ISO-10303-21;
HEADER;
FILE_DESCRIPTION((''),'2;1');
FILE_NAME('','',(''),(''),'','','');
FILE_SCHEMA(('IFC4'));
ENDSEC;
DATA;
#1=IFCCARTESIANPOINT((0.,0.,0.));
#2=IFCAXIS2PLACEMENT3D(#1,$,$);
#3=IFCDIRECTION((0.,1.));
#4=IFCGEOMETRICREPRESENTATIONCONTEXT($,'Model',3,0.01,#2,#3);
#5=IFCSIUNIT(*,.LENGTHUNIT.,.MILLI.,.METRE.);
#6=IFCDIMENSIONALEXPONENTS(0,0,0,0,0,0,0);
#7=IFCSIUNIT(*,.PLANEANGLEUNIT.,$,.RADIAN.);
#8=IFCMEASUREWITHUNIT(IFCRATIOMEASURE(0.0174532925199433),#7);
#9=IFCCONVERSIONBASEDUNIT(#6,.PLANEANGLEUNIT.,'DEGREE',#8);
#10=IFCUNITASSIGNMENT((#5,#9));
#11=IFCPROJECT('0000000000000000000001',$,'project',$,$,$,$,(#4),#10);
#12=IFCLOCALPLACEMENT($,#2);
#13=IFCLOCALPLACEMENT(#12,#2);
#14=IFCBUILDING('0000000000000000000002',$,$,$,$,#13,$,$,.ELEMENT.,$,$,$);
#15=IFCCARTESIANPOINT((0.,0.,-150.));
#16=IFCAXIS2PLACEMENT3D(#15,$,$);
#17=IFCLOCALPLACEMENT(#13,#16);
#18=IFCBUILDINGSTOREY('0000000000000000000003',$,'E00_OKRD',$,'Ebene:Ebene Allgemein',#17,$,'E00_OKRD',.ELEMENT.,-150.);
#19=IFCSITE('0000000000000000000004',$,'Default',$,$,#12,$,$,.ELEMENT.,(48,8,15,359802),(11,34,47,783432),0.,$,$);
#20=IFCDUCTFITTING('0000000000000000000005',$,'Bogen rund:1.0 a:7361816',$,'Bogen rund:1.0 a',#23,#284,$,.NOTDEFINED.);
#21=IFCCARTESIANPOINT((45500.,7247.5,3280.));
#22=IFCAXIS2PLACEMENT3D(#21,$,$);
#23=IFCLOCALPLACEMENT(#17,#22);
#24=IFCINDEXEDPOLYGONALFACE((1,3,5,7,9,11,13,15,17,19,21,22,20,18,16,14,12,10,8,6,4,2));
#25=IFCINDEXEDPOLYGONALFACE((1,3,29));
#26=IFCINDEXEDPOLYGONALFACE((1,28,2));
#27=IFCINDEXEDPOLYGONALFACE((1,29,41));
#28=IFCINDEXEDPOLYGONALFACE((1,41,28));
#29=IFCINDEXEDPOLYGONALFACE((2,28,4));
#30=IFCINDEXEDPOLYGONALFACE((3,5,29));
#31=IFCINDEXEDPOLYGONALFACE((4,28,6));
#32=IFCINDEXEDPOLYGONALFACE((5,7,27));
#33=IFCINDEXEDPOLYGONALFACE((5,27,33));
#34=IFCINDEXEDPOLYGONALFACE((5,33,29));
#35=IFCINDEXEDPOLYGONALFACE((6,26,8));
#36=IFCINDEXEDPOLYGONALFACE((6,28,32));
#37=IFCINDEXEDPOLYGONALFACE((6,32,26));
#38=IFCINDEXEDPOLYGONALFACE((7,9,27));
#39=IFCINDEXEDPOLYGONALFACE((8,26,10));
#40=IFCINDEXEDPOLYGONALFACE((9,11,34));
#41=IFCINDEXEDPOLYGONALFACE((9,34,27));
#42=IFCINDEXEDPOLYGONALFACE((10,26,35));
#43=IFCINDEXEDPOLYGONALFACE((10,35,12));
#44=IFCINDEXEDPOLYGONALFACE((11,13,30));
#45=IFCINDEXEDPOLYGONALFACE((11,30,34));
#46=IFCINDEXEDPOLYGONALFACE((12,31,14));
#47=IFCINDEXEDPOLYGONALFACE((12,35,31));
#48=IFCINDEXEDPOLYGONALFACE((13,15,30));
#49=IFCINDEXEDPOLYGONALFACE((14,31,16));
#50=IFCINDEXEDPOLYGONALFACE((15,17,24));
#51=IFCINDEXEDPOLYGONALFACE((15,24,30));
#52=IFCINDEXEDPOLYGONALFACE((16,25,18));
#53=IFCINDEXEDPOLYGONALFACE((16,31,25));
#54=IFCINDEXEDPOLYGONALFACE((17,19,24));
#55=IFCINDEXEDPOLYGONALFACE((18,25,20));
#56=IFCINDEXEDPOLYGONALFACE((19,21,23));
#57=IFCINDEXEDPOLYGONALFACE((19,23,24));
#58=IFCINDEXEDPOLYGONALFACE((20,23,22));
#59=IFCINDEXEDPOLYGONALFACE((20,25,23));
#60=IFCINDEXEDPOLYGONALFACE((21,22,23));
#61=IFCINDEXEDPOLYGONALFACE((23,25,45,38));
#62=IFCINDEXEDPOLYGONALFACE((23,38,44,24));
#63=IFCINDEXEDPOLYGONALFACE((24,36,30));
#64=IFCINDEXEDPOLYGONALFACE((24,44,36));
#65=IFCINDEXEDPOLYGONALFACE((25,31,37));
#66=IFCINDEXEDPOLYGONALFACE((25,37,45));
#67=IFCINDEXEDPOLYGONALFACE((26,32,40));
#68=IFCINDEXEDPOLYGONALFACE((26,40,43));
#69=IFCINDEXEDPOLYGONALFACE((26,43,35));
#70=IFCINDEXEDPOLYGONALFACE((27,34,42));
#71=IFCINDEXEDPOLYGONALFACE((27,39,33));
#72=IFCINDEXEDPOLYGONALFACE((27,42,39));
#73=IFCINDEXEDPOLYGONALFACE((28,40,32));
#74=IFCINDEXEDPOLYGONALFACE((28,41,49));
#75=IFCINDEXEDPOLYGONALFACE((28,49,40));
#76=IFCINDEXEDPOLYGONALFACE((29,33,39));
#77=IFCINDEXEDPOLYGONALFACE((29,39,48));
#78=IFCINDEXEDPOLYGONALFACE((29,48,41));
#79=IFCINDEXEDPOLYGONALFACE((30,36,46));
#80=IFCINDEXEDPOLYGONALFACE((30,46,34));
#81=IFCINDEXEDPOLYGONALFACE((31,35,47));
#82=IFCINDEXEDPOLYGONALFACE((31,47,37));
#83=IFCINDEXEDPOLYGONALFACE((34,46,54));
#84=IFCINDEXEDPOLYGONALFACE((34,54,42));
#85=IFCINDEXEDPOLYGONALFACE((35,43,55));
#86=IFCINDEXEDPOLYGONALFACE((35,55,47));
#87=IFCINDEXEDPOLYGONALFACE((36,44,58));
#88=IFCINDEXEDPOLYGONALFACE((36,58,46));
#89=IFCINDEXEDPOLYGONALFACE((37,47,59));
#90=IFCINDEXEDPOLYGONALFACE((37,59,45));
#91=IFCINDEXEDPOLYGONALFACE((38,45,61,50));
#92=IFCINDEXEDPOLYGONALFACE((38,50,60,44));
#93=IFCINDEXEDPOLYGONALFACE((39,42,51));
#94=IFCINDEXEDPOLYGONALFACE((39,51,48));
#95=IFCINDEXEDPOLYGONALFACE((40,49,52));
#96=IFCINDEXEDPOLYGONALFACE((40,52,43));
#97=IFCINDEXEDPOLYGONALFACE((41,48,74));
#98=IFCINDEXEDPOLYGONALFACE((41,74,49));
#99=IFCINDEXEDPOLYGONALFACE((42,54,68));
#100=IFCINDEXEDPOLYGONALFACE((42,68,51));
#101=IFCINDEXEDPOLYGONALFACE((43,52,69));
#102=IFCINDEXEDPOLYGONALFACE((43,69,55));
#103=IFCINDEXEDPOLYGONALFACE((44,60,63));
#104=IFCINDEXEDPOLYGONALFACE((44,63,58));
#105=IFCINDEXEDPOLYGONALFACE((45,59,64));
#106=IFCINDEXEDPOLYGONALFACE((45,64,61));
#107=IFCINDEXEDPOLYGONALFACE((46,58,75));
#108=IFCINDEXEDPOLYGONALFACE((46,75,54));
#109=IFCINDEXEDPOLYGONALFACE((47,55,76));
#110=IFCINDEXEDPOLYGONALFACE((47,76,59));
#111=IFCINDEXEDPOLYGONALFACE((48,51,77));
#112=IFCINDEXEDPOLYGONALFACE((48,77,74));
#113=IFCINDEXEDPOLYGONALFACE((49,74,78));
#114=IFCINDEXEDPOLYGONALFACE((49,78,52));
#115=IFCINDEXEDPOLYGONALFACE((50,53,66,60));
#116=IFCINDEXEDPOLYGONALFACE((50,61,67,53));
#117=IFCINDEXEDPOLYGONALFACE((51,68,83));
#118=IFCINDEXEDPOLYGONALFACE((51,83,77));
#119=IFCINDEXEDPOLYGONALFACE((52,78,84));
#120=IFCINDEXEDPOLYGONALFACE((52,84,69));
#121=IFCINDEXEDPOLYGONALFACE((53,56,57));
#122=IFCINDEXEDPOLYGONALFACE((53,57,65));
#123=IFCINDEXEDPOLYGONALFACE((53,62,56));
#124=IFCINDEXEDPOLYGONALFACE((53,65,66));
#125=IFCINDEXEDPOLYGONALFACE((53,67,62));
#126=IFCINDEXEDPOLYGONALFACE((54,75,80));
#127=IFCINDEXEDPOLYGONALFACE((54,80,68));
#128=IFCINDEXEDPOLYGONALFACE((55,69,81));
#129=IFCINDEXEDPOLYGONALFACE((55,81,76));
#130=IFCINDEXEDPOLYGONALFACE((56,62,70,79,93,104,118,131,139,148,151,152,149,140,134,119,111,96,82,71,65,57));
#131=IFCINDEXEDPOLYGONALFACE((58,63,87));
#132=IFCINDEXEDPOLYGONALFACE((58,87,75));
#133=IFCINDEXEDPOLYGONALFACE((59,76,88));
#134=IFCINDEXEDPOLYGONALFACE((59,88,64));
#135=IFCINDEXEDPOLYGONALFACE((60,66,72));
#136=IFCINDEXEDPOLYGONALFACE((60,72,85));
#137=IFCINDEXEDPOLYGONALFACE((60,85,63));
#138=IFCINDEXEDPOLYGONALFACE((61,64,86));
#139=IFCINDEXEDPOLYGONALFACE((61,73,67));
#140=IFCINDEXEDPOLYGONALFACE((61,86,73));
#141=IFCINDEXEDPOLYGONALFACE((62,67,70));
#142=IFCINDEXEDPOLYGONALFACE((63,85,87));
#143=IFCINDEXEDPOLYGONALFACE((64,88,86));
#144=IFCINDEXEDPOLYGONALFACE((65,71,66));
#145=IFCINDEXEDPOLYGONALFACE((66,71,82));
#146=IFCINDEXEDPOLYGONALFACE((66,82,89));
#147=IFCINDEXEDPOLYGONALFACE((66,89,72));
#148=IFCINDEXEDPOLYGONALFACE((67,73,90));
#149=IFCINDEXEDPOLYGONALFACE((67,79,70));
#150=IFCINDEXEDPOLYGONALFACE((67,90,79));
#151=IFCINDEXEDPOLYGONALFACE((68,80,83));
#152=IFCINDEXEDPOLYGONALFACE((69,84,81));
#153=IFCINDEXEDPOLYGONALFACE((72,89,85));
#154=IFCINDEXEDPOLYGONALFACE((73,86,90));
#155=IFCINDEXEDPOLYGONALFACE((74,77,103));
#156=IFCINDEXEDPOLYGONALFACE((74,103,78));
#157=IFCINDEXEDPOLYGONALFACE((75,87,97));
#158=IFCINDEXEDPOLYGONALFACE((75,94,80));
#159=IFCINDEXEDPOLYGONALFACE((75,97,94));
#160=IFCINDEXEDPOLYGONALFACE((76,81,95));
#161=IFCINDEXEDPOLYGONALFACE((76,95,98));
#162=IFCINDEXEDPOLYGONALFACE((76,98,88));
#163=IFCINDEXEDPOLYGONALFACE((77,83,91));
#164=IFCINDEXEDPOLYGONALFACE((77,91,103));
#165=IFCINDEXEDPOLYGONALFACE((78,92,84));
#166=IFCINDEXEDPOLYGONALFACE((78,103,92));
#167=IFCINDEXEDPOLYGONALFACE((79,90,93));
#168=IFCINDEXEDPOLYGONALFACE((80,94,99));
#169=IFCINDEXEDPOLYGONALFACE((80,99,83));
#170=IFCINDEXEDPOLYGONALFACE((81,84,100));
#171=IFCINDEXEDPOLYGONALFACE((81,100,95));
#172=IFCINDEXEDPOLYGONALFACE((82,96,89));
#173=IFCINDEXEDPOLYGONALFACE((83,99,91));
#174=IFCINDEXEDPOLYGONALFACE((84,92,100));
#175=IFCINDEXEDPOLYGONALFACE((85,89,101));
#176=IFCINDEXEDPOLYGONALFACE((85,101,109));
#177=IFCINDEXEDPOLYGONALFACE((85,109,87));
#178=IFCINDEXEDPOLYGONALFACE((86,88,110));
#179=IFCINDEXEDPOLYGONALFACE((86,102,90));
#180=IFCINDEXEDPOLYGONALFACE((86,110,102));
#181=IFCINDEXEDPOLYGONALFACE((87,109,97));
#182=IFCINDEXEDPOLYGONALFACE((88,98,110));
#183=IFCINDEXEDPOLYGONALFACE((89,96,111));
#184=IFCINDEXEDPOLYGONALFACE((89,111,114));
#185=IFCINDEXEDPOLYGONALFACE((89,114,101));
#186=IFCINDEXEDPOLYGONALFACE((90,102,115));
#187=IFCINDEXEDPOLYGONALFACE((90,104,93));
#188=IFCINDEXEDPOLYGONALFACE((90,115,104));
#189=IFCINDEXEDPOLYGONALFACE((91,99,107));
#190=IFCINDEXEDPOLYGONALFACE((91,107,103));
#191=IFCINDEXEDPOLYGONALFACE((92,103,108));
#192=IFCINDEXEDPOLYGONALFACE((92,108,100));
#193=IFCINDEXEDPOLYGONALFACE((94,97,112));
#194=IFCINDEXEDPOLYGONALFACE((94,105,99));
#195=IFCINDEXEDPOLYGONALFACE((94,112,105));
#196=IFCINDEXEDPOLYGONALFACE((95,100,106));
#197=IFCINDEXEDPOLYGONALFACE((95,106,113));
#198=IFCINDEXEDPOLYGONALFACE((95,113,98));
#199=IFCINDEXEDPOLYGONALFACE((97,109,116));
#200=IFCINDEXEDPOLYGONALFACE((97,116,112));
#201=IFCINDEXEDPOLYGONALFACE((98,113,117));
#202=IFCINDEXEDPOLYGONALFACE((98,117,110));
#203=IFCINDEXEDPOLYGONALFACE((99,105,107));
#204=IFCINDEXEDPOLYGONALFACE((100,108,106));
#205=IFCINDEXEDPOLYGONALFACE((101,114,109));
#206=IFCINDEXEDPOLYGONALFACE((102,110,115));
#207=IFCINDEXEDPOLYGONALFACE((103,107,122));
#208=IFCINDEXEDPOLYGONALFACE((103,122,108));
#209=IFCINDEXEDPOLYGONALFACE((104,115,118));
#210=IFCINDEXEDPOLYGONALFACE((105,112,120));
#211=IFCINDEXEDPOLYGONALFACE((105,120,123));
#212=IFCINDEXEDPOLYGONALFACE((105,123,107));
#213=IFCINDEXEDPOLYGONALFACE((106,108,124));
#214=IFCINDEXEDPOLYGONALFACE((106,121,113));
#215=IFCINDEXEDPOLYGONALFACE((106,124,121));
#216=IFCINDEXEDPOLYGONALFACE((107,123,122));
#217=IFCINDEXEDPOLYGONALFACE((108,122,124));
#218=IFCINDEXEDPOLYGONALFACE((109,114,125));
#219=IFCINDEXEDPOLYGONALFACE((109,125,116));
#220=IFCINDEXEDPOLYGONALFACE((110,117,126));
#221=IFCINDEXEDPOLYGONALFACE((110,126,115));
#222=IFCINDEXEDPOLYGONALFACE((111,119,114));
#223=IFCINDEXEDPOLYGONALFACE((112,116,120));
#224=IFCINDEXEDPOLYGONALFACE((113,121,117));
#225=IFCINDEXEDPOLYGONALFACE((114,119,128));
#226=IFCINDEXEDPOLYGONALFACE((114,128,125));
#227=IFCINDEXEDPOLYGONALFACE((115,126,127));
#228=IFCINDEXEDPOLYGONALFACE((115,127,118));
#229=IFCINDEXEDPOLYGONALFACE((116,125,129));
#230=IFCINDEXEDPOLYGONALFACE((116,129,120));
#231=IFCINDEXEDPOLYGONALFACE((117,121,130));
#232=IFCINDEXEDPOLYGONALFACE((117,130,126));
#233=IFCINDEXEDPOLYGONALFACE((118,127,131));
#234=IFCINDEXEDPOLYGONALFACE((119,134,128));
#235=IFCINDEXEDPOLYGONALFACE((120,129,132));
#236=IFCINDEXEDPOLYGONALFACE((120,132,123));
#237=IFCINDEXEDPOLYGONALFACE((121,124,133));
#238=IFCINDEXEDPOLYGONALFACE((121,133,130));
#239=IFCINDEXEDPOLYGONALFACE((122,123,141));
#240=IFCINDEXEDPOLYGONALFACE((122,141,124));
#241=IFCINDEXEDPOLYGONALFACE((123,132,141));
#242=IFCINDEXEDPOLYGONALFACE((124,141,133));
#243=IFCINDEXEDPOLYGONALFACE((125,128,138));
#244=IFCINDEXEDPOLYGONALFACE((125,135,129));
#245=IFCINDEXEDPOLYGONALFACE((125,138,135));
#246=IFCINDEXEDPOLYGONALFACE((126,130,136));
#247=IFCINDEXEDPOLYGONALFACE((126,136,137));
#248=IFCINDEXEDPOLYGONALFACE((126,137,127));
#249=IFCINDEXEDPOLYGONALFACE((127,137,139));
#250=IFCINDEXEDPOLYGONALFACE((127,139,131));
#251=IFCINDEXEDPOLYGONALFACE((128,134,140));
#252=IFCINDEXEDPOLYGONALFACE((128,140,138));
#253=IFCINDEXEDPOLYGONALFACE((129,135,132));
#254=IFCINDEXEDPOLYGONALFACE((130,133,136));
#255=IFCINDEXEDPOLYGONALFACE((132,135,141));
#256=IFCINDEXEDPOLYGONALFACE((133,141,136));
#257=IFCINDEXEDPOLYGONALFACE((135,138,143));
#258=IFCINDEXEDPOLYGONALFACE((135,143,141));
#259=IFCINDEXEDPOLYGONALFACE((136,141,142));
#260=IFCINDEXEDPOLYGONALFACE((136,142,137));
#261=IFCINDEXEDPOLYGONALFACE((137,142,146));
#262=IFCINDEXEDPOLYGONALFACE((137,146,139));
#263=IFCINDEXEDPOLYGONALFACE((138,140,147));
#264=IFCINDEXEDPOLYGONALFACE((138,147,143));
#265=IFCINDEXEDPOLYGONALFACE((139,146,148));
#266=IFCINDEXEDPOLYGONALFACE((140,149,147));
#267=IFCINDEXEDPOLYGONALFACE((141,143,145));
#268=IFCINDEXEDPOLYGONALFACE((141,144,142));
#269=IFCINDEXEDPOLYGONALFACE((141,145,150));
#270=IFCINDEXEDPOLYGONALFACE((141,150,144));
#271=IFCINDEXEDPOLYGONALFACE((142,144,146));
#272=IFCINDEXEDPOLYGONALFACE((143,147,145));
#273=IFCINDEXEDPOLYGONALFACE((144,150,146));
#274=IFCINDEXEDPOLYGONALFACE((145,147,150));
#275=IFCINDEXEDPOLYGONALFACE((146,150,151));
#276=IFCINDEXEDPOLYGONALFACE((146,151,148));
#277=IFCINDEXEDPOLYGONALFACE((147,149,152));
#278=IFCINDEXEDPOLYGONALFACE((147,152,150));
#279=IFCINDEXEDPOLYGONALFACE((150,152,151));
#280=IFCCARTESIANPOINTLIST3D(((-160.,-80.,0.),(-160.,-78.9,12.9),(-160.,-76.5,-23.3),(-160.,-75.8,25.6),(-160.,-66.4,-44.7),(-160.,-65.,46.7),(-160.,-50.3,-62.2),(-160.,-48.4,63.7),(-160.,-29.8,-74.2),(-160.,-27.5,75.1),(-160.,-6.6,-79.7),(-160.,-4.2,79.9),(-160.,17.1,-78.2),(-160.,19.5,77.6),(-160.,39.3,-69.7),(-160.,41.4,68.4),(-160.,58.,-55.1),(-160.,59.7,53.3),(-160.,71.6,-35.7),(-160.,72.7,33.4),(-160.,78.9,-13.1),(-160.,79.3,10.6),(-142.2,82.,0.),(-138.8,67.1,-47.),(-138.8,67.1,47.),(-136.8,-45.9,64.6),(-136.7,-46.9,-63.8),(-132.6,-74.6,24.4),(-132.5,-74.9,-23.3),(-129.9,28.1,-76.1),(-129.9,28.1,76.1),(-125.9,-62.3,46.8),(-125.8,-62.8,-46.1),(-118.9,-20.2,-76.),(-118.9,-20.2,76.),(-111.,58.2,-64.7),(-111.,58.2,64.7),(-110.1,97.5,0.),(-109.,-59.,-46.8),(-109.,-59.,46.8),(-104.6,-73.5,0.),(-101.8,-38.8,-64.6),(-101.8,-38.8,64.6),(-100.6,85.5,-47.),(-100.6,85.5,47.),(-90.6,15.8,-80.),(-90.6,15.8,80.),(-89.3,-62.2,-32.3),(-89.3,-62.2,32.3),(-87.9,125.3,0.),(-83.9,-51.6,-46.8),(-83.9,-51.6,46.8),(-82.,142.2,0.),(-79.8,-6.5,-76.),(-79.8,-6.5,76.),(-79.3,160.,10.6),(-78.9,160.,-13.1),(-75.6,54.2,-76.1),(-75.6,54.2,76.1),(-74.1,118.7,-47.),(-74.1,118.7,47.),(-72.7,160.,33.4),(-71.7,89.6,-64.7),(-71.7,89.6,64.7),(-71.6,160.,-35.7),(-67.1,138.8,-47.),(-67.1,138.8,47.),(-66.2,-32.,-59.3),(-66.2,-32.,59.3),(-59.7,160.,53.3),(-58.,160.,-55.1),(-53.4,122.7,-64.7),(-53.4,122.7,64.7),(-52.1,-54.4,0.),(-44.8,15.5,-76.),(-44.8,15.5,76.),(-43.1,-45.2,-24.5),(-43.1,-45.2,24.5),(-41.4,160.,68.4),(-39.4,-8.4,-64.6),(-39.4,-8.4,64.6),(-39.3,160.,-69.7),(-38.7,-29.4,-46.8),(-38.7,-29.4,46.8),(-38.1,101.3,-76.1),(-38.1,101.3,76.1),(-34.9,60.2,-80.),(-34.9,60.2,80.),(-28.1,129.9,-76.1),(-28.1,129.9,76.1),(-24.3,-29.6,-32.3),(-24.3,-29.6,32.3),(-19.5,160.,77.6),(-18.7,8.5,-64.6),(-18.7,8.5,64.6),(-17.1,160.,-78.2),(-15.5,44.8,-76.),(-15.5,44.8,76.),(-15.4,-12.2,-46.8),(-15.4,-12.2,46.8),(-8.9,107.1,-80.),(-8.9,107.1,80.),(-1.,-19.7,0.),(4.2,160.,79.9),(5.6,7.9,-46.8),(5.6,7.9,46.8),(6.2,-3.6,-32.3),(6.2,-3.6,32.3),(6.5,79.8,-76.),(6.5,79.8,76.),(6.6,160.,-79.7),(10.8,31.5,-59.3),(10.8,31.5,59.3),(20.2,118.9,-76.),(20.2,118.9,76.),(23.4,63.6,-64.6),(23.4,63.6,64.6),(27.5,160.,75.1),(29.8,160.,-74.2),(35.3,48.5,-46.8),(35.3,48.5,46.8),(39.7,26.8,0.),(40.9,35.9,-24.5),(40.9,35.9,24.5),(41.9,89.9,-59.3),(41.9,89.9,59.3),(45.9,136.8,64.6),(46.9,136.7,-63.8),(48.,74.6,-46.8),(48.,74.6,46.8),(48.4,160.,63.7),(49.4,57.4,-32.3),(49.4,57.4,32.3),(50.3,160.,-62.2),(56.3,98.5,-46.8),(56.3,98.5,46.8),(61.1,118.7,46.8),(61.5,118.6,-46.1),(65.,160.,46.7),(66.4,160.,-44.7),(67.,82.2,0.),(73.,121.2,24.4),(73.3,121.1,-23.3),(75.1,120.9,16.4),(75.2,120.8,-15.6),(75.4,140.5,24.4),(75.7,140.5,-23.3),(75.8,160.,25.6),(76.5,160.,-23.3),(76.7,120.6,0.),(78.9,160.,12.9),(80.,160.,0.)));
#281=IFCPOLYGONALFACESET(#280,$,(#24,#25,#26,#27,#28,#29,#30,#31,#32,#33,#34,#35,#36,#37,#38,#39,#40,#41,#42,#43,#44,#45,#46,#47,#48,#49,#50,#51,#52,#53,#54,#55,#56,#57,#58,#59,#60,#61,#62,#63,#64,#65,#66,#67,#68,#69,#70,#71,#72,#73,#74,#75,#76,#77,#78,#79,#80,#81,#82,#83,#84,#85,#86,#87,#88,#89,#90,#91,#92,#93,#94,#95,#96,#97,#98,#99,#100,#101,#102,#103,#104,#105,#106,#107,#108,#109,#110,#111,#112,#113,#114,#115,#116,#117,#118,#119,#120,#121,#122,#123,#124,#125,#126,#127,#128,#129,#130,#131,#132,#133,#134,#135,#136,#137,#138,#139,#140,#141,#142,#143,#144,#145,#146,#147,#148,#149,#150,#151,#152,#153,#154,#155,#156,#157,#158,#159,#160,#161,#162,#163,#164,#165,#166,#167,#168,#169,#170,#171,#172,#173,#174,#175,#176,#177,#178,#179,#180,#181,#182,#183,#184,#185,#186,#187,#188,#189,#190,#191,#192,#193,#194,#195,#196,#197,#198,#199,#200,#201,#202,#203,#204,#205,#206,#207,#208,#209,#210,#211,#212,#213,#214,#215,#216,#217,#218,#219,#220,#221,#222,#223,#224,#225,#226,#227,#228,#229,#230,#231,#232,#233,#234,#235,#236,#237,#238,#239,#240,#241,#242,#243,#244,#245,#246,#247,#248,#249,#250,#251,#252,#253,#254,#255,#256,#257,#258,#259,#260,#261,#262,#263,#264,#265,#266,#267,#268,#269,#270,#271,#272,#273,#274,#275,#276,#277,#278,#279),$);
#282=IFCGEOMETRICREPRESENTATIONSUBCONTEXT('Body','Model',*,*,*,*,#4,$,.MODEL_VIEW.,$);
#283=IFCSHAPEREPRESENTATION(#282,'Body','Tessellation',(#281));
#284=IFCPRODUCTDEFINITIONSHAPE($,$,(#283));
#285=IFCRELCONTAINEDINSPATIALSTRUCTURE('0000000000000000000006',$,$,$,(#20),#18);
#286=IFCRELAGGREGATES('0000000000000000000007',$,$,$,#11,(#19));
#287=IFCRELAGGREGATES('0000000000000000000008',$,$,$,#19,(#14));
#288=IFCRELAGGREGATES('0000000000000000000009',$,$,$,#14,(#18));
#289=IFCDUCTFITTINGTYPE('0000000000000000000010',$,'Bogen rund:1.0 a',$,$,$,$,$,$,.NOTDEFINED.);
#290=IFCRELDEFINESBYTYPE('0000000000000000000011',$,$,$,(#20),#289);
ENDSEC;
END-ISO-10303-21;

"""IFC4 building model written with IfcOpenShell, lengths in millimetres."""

from ifc_helpers import new_model, entity, si_unit, converted_unit, direction, frame, origin, place, context, subcontext, project, spatial, source, transform, mapped, type_object, type_shapes, element, save


model = new_model("IFC4")

# Units and contexts
model_context = context("Model", 3, precision=0.01, world=origin(), true_north=direction((0.0, 1.0)))
body_context = subcontext(model_context, "Body", "Model", "MODEL_VIEW")
ifc_project = project(units=[si_unit("LENGTHUNIT", "METRE", prefix="MILLI"), converted_unit("PLANEANGLEUNIT", "DEGREE", entity("IfcRatioMeasure", 0.0174532925199433), si_unit("PLANEANGLEUNIT", "RADIAN"), dimensions=[0, 0, 0, 0, 0, 0, 0])], contexts=[model_context])

# Site, building, storey
site_placement = place(None, origin())
site = spatial("IfcSite", under=ifc_project, at=site_placement, Name="Default", CompositionType="ELEMENT", RefLatitude=(48, 8, 15, 359802), RefLongitude=(11, 34, 47, 783432), RefElevation=0.0)
building_placement = place(site_placement, origin())
building = spatial("IfcBuilding", under=site, at=building_placement, CompositionType="ELEMENT")
storey_placement = place(building_placement, frame((0.0, 0.0, -150.0)))
storey = spatial("IfcBuildingStorey", under=building, at=storey_placement, Name="E00_OKRD", ObjectType="Ebene:Ebene Allgemein", LongName="E00_OKRD", CompositionType="ELEMENT", Elevation=-150.0)

# Duct fitting
duct_fitting_type_1 = type_object("IfcDuctFittingType", Name="Bogen rund:1.0 a", PredefinedType="NOTDEFINED")
ifc_direction = entity("IfcDirection", [0.0, 0.0, 1.0])
trimmed_curve = entity("IfcTrimmedCurve", entity("IfcCircle", entity("IfcAxis2Placement2D", entity("IfcCartesianPoint", [-160.0, 0.0]), entity("IfcDirection", [0.0, 1.0])), 160.0), [entity("IfcParameterValue", 270.0)], [entity("IfcParameterValue", 0.0)], True, "PARAMETER")
shared_shape_1 = source(origin(), body_context, "Body", "AdvancedSweptSolid", [
    entity("IfcSurfaceCurveSweptAreaSolid", entity("IfcCircleProfileDef", "AREA", None, entity("IfcAxis2Placement2D", entity("IfcCartesianPoint", [0.0, 0.0]), entity("IfcDirection", [1.0, 0.0])), 80.0), entity("IfcAxis2Placement3D", entity("IfcCartesianPoint", [-160.0, 0.0, 0.0]), ifc_direction, entity("IfcDirection", [0.0, -1.0, 0.0])), trimmed_curve, 0.0, 90.0, entity("IfcSurfaceOfLinearExtrusion", entity("IfcArbitraryOpenProfileDef", "CURVE", None, trimmed_curve), entity("IfcAxis2Placement3D", entity("IfcCartesianPoint", [0.0, 0.0, -304.8])), ifc_direction, 1.0)),
])
type_shapes(duct_fitting_type_1, [shared_shape_1])
duct_fitting_1_placement = place(storey_placement, frame((45500.0, 7247.5, 3280.0)))
element("IfcDuctFitting", 1, at=duct_fitting_1_placement, inside=storey, type_object=duct_fitting_type_1, Name="Bogen rund:1.0 a:7361816", ObjectType="Bogen rund:1.0 a", PredefinedType="NOTDEFINED", context=body_context, shape_type="MappedRepresentation", body=[
    mapped(shared_shape_1, transform((0.0, 0.0, 0.0), scale=1.0)),
])

save(model, "model.ifc")
